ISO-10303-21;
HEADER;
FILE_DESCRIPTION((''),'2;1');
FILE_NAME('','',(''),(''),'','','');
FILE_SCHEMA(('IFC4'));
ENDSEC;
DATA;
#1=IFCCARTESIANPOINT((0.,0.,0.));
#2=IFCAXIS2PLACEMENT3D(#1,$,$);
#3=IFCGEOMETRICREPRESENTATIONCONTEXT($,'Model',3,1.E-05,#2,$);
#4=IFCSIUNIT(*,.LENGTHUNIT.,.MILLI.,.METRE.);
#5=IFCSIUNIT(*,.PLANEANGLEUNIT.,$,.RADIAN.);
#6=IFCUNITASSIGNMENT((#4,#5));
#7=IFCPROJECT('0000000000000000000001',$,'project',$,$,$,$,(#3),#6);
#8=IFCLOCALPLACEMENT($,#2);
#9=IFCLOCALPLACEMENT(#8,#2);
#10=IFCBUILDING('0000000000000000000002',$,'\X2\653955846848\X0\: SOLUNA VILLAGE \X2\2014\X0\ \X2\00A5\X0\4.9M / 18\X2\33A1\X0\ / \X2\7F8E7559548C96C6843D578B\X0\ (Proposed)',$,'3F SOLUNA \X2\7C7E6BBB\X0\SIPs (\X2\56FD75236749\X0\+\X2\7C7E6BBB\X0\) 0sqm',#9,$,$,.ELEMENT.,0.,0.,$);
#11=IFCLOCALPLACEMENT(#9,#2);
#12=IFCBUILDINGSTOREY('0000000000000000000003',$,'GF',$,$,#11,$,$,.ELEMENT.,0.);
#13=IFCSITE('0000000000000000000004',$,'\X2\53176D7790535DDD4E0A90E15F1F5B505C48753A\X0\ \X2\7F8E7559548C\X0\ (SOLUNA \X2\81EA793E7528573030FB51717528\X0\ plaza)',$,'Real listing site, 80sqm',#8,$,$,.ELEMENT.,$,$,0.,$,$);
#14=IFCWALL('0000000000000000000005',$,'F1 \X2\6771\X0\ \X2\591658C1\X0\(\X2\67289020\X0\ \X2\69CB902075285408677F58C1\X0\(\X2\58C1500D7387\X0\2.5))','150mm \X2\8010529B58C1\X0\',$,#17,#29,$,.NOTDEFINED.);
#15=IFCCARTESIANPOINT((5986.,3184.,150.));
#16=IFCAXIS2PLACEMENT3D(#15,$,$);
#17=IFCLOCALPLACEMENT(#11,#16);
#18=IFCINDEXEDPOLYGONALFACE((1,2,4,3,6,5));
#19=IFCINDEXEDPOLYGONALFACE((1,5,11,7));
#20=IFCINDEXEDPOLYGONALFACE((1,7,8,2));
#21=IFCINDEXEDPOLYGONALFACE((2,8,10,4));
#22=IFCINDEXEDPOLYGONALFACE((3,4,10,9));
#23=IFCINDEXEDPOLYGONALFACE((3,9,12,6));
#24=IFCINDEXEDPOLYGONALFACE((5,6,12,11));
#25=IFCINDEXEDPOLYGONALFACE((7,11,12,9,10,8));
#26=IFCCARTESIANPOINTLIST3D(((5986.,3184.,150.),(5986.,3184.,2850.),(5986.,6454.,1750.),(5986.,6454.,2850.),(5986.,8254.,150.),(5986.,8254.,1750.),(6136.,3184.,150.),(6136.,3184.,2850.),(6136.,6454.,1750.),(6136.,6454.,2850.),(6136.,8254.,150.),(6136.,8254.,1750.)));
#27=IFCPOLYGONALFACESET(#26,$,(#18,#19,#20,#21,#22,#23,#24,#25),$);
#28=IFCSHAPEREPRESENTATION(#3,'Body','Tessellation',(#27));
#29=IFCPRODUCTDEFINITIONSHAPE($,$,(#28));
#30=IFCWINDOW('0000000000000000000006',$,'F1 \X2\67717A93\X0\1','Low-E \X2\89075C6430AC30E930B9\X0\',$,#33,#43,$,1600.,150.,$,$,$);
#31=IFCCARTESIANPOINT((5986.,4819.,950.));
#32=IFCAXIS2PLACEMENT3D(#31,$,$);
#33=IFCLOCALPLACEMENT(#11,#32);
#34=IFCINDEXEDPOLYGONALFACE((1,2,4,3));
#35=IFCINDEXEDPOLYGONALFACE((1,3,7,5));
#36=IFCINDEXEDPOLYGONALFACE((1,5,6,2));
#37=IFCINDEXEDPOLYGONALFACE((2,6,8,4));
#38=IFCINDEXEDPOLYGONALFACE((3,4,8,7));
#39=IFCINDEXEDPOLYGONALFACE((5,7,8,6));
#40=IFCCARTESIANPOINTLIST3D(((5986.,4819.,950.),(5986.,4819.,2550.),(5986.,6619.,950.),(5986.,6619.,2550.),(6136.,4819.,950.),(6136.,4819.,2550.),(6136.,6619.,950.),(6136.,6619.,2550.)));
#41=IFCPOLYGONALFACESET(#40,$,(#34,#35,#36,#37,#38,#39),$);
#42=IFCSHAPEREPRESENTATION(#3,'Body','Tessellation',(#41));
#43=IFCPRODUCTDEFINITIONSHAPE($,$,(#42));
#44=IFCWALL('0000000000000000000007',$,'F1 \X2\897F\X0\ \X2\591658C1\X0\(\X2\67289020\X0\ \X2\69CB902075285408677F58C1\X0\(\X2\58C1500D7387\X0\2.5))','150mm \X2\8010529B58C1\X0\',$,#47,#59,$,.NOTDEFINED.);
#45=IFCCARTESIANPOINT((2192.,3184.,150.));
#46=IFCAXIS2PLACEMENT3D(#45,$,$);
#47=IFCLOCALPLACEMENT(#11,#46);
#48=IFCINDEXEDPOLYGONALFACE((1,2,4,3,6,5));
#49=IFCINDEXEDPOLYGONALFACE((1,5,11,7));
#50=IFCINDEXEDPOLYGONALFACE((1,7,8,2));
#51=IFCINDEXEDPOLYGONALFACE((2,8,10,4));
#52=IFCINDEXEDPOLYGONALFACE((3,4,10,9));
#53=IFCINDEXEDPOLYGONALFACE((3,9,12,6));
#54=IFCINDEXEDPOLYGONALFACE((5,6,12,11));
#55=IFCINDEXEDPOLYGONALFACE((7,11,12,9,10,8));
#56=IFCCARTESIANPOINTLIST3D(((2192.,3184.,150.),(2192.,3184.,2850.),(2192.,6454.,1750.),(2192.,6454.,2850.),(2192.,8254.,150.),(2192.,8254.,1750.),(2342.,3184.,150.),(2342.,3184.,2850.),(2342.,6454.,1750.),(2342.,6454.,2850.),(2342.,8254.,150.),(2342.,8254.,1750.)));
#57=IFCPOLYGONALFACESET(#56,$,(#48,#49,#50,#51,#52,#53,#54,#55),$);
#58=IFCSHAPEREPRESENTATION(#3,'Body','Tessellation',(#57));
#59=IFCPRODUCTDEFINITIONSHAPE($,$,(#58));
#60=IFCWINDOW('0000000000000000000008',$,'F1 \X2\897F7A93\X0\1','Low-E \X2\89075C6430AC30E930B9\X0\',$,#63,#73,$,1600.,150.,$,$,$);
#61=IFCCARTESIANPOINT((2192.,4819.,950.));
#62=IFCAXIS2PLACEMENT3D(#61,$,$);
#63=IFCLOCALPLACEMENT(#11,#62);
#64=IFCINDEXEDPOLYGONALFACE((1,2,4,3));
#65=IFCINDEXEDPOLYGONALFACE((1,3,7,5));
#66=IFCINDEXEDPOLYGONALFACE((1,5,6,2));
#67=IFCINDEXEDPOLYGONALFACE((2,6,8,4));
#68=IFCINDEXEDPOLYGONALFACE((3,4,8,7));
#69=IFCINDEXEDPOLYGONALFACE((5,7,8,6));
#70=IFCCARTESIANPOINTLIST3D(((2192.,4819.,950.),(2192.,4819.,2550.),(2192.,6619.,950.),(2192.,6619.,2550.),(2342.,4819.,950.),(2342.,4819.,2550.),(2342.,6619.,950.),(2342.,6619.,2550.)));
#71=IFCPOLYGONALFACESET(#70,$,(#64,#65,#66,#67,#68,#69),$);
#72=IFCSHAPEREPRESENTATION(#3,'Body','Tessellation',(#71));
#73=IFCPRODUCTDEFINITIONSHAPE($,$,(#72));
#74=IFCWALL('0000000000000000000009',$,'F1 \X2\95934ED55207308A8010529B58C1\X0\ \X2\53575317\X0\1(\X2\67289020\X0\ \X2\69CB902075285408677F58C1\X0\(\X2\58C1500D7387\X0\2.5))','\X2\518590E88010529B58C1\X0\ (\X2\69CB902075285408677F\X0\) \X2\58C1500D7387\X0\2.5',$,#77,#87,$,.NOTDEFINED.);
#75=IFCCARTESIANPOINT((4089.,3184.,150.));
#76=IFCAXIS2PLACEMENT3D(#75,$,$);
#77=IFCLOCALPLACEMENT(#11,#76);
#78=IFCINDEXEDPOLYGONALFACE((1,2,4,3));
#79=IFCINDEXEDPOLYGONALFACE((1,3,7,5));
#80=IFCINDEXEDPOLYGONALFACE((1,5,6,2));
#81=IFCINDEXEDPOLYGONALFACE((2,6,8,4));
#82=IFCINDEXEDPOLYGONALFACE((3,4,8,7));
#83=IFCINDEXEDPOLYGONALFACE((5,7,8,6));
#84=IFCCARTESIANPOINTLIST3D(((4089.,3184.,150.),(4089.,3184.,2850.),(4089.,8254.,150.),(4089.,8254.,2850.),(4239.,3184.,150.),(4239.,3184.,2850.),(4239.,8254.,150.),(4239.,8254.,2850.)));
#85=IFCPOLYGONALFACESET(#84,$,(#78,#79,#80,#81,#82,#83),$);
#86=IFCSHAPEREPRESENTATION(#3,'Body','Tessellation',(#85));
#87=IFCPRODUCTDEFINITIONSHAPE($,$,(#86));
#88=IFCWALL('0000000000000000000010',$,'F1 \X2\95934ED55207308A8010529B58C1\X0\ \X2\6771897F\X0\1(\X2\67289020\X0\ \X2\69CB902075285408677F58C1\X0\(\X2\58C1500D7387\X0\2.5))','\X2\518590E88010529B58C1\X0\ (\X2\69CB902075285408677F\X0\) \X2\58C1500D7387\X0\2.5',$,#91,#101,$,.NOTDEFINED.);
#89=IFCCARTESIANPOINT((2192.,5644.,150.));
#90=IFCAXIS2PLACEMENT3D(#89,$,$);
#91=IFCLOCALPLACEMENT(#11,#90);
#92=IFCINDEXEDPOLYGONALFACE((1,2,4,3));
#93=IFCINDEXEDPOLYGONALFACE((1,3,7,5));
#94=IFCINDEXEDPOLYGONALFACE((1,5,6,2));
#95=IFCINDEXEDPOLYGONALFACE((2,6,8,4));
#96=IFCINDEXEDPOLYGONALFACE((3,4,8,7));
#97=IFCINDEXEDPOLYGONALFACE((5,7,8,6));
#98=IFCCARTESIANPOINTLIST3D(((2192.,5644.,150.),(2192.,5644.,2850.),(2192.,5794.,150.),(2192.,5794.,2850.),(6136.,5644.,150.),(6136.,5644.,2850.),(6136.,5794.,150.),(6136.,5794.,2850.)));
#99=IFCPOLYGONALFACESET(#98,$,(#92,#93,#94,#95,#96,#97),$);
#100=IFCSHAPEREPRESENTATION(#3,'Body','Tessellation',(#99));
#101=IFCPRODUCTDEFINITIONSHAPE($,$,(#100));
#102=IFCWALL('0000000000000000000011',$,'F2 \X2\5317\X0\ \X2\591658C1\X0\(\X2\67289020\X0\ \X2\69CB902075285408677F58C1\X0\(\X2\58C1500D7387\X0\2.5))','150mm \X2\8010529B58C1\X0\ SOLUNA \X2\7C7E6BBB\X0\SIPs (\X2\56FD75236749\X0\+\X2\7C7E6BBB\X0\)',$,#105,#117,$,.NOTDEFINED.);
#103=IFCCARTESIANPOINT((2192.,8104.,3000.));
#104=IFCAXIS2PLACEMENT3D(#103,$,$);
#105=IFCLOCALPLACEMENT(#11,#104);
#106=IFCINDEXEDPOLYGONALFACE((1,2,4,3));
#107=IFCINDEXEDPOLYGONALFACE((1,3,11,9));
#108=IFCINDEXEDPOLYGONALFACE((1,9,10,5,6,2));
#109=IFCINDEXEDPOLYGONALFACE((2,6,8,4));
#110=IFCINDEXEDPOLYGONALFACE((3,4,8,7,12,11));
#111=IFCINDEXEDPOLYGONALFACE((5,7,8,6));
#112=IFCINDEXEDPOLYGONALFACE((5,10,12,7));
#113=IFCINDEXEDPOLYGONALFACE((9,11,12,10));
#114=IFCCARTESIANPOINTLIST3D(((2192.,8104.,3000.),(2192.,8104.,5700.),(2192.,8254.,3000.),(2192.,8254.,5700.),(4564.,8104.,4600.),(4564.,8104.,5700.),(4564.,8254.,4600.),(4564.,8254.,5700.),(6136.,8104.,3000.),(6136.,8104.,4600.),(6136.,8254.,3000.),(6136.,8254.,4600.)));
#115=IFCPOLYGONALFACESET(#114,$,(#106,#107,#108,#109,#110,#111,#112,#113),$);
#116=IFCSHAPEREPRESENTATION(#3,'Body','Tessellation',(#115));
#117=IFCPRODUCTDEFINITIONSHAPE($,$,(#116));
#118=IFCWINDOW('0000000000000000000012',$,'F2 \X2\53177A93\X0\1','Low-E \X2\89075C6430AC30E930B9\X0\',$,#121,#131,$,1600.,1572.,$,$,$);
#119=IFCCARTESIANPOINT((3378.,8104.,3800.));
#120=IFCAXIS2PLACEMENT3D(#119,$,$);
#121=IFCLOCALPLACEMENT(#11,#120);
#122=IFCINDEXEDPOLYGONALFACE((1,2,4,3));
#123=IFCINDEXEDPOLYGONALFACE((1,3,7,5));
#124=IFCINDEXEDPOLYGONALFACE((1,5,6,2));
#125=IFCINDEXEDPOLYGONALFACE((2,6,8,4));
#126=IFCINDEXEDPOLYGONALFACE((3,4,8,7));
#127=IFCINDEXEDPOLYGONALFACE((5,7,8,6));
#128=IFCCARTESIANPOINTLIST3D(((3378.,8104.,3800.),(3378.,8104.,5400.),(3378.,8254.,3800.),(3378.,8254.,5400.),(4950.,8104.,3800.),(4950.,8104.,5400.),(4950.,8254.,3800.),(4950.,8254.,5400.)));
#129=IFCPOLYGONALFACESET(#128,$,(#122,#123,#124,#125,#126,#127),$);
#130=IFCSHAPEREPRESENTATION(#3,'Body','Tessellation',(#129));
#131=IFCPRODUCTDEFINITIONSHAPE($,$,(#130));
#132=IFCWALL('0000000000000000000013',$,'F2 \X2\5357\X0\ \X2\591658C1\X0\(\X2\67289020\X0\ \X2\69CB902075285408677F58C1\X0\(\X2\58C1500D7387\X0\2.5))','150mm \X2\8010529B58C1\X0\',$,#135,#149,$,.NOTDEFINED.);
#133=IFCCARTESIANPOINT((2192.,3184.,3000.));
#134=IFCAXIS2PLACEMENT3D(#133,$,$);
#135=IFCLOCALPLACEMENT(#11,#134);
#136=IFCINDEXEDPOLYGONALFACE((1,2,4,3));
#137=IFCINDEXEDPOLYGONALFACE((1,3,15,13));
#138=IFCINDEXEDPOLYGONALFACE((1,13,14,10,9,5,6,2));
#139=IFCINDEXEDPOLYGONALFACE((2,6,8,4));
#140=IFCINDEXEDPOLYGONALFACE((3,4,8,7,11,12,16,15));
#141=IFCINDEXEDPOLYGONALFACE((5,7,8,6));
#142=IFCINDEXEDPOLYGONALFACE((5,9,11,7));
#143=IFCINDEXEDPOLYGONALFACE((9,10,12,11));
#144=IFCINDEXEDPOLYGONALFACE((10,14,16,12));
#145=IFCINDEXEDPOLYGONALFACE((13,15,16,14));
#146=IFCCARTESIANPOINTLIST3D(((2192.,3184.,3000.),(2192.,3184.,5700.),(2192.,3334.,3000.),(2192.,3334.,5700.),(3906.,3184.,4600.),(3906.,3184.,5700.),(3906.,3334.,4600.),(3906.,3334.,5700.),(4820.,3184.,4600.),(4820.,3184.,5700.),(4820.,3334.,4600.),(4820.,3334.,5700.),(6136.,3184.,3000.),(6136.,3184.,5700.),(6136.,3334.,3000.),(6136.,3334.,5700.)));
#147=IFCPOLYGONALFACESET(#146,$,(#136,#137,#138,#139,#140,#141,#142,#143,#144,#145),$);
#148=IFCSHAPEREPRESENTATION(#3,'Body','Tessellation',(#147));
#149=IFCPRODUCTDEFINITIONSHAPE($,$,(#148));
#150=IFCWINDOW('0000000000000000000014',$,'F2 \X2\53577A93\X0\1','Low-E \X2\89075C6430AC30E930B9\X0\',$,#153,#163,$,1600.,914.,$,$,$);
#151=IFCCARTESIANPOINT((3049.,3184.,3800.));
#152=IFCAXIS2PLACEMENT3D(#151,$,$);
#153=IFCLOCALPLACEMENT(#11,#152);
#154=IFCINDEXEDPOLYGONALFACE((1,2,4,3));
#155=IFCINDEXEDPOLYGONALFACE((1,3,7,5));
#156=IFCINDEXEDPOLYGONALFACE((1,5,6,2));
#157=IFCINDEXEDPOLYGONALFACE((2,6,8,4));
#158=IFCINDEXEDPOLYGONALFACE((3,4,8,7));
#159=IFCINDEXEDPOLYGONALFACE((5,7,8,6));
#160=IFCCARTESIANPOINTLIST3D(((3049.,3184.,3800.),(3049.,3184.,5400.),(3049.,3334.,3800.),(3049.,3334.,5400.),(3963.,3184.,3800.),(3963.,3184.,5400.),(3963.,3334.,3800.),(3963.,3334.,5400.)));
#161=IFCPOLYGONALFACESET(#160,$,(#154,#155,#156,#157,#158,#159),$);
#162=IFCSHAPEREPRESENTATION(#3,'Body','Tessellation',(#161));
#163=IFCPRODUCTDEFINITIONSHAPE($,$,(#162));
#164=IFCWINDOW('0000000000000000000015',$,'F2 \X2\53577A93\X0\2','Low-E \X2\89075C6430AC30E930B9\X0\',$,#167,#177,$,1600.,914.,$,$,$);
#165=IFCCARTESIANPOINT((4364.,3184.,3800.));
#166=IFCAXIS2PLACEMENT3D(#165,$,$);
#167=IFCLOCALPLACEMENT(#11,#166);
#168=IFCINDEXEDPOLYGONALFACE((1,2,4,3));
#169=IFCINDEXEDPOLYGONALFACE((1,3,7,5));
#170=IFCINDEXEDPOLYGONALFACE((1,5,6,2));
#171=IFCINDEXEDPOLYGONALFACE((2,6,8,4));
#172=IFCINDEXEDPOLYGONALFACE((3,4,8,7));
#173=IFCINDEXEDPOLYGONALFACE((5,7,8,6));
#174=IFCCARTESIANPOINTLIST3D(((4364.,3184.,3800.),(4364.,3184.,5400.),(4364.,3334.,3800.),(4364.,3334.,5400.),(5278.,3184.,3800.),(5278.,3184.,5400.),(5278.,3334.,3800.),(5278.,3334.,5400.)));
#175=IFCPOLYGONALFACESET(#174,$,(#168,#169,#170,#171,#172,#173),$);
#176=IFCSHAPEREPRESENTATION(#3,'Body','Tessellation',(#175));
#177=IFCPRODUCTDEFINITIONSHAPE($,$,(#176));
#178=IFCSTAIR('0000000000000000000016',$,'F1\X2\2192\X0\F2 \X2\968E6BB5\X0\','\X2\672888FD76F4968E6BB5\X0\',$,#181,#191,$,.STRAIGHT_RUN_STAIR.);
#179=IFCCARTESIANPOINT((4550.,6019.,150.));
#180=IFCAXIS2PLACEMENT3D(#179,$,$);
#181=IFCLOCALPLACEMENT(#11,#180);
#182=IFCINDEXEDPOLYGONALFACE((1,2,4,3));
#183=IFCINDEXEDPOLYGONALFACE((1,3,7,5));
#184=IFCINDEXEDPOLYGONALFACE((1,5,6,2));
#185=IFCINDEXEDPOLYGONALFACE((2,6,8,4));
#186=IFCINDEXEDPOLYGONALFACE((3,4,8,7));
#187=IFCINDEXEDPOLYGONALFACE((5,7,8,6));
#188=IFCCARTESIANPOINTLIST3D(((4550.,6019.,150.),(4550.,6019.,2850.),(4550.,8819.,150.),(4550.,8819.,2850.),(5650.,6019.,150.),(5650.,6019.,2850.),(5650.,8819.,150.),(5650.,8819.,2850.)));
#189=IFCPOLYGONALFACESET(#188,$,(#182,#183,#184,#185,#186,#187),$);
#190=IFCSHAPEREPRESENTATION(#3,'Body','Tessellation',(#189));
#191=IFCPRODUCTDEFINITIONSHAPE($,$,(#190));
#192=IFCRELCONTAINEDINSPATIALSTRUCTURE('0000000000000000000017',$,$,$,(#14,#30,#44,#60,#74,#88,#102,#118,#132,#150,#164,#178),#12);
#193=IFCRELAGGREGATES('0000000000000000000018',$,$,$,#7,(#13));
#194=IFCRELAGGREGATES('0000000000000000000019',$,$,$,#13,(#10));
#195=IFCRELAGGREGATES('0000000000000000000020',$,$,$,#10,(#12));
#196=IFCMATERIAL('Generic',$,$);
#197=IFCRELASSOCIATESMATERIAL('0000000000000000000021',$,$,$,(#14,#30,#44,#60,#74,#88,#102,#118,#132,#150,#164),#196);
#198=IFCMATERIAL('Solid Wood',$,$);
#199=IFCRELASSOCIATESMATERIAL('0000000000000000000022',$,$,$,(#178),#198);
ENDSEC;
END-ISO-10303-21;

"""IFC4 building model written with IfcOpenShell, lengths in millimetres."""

from ifc_helpers import new_model, si_unit, frame, frame_2d, origin, place, context, project, spatial, rectangle, extrude, material, element, fill, save


model = new_model("IFC4")

# Units and contexts
model_context = context("Model", 3, precision=1e-05, world=origin())
ifc_project = project(units=[si_unit("LENGTHUNIT", "METRE", prefix="MILLI"), si_unit("PLANEANGLEUNIT", "RADIAN")], contexts=[model_context])

# Site, building, storey
site_placement = place(None, origin())
site = spatial("IfcSite", under=ifc_project, at=site_placement, Name="北海道川上郡弟子屈町 美留和 (SOLUNA 自社用地・共用 plaza)", ObjectType="Real listing site, 80sqm", CompositionType="ELEMENT", RefElevation=0.0)
building_placement = place(site_placement, origin())
building = spatial("IfcBuilding", under=site, at=building_placement, Name="改善案: SOLUNA VILLAGE — ¥4.9M / 18㎡ / 美留和集落型 (Proposed)", ObjectType="3F SOLUNA 籾殻SIPs (国産杉+籾殻) 0sqm", CompositionType="ELEMENT", ElevationOfRefHeight=0.0, ElevationOfTerrain=0.0)
storey_placement = place(building_placement, origin())
storey = spatial("IfcBuildingStorey", under=building, at=storey_placement, Name="GF", CompositionType="ELEMENT", Elevation=0.0)

# Shared definitions
ifc_material_1 = material(Name="Generic")

# Shared definitions
ifc_material_2 = material(Name="Solid Wood")

# Walls, openings, windows
wall_1_placement = place(storey_placement, frame((5986.0, 3184.0, 150.0)))
wall_1 = element("IfcWall", 1, at=wall_1_placement, inside=storey, material=ifc_material_1, Name="F1 東 外壁(木造 構造用合板壁(壁倍率2.5))", Description="150mm 耐力壁", PredefinedType="NOTDEFINED", context=model_context, shape_type="SweptSolid", body=[
    extrude(rectangle(XDim=150.0, YDim=5070.0, at=frame_2d((75.0, 2535.0))), frame((5986.0, 3184.0, 150.0)), (0.0, 0.0, 1.0), 2700.0),
])
opening_1_placement = place(storey_placement, frame((5986.0, 4819.0, 950.0)))
opening_1 = element("IfcOpeningElement", 2, at=opening_1_placement, cuts=wall_1, PredefinedType="NOTDEFINED", context=model_context, shape_type="SweptSolid", body=[
    extrude(rectangle(XDim=150.0, YDim=1800.0, at=frame_2d((75.0, 900.0))), frame((5986.0, 4819.0, 950.0)), (0.0, 0.0, 1.0), 1600.0),
])
window_1_placement = place(storey_placement, frame((5986.0, 4819.0, 950.0)))
window_1 = element("IfcWindow", 3, at=window_1_placement, inside=storey, material=ifc_material_1, Name="F1 東窓1", Description="Low-E 複層ガラス", OverallHeight=1600.0, OverallWidth=150.0, context=model_context, shape_type="SweptSolid", body=[
    extrude(rectangle(XDim=150.0, YDim=1800.0, at=frame_2d((75.0, 900.0))), frame((5986.0, 4819.0, 950.0)), (0.0, 0.0, 1.0), 1600.0),
])
fill(opening_1, window_1)
wall_2_placement = place(storey_placement, frame((2192.0, 3184.0, 150.0)))
wall_2 = element("IfcWall", 4, at=wall_2_placement, inside=storey, material=ifc_material_1, Name="F1 西 外壁(木造 構造用合板壁(壁倍率2.5))", Description="150mm 耐力壁", PredefinedType="NOTDEFINED", context=model_context, shape_type="SweptSolid", body=[
    extrude(rectangle(XDim=150.0, YDim=5070.0, at=frame_2d((75.0, 2535.0))), frame((2192.0, 3184.0, 150.0)), (0.0, 0.0, 1.0), 2700.0),
])
opening_2_placement = place(storey_placement, frame((2192.0, 4819.0, 950.0)))
opening_2 = element("IfcOpeningElement", 5, at=opening_2_placement, cuts=wall_2, PredefinedType="NOTDEFINED", context=model_context, shape_type="SweptSolid", body=[
    extrude(rectangle(XDim=150.0, YDim=1800.0, at=frame_2d((75.0, 900.0))), frame((2192.0, 4819.0, 950.0)), (0.0, 0.0, 1.0), 1600.0),
])
window_2_placement = place(storey_placement, frame((2192.0, 4819.0, 950.0)))
window_2 = element("IfcWindow", 6, at=window_2_placement, inside=storey, material=ifc_material_1, Name="F1 西窓1", Description="Low-E 複層ガラス", OverallHeight=1600.0, OverallWidth=150.0, context=model_context, shape_type="SweptSolid", body=[
    extrude(rectangle(XDim=150.0, YDim=1800.0, at=frame_2d((75.0, 900.0))), frame((2192.0, 4819.0, 950.0)), (0.0, 0.0, 1.0), 1600.0),
])
fill(opening_2, window_2)

# Walls
wall_3_placement = place(storey_placement, frame((4089.0, 3184.0, 150.0)))
element("IfcWall", 7, at=wall_3_placement, inside=storey, material=ifc_material_1, Name="F1 間仕切り耐力壁 南北1(木造 構造用合板壁(壁倍率2.5))", Description="内部耐力壁 (構造用合板) 壁倍率2.5", PredefinedType="NOTDEFINED", context=model_context, shape_type="SweptSolid", body=[
    extrude(rectangle(XDim=150.0, YDim=5070.0, at=frame_2d((75.0, 2535.0))), frame((4089.0, 3184.0, 150.0)), (0.0, 0.0, 1.0), 2700.0),
])
wall_4_placement = place(storey_placement, frame((2192.0, 5644.0, 150.0)))
element("IfcWall", 8, at=wall_4_placement, inside=storey, material=ifc_material_1, Name="F1 間仕切り耐力壁 東西1(木造 構造用合板壁(壁倍率2.5))", Description="内部耐力壁 (構造用合板) 壁倍率2.5", PredefinedType="NOTDEFINED", context=model_context, shape_type="SweptSolid", body=[
    extrude(rectangle(XDim=3944.0, YDim=150.0, at=frame_2d((1972.0, 75.0))), frame((2192.0, 5644.0, 150.0)), (0.0, 0.0, 1.0), 2700.0),
])

# Wall, opening, window
wall_5_placement = place(storey_placement, frame((2192.0, 8104.0, 3000.0)))
wall_5 = element("IfcWall", 9, at=wall_5_placement, inside=storey, material=ifc_material_1, Name="F2 北 外壁(木造 構造用合板壁(壁倍率2.5))", Description="150mm 耐力壁 SOLUNA 籾殻SIPs (国産杉+籾殻)", PredefinedType="NOTDEFINED", context=model_context, shape_type="SweptSolid", body=[
    extrude(rectangle(XDim=3944.0, YDim=150.0, at=frame_2d((1972.0, 75.0))), frame((2192.0, 8104.0, 3000.0)), (0.0, 0.0, 1.0), 2700.0),
])
opening_3_placement = place(storey_placement, frame((3378.0, 8104.0, 3800.0)))
opening_3 = element("IfcOpeningElement", 10, at=opening_3_placement, cuts=wall_5, PredefinedType="NOTDEFINED", context=model_context, shape_type="SweptSolid", body=[
    extrude(rectangle(XDim=1572.0, YDim=150.0, at=frame_2d((786.0, 75.0))), frame((3378.0, 8104.0, 3800.0)), (0.0, 0.0, 1.0), 1600.0),
])
window_3_placement = place(storey_placement, frame((3378.0, 8104.0, 3800.0)))
window_3 = element("IfcWindow", 11, at=window_3_placement, inside=storey, material=ifc_material_1, Name="F2 北窓1", Description="Low-E 複層ガラス", OverallHeight=1600.0, OverallWidth=1572.0, context=model_context, shape_type="SweptSolid", body=[
    extrude(rectangle(XDim=1572.0, YDim=150.0, at=frame_2d((786.0, 75.0))), frame((3378.0, 8104.0, 3800.0)), (0.0, 0.0, 1.0), 1600.0),
])
fill(opening_3, window_3)

# Wall, openings, windows
wall_6_placement = place(storey_placement, frame((2192.0, 3184.0, 3000.0)))
wall_6 = element("IfcWall", 12, at=wall_6_placement, inside=storey, material=ifc_material_1, Name="F2 南 外壁(木造 構造用合板壁(壁倍率2.5))", Description="150mm 耐力壁", PredefinedType="NOTDEFINED", context=model_context, shape_type="SweptSolid", body=[
    extrude(rectangle(XDim=3944.0, YDim=150.0, at=frame_2d((1972.0, 75.0))), frame((2192.0, 3184.0, 3000.0)), (0.0, 0.0, 1.0), 2700.0),
])
opening_4_placement = place(storey_placement, frame((3049.0, 3184.0, 3800.0)))
opening_4 = element("IfcOpeningElement", 13, at=opening_4_placement, cuts=wall_6, PredefinedType="NOTDEFINED", context=model_context, shape_type="SweptSolid", body=[
    extrude(rectangle(XDim=914.0, YDim=150.0, at=frame_2d((457.0, 75.0))), frame((3049.0, 3184.0, 3800.0)), (0.0, 0.0, 1.0), 1600.0),
])
opening_5_placement = place(storey_placement, frame((4364.0, 3184.0, 3800.0)))
opening_5 = element("IfcOpeningElement", 14, at=opening_5_placement, cuts=wall_6, PredefinedType="NOTDEFINED", context=model_context, shape_type="SweptSolid", body=[
    extrude(rectangle(XDim=914.0, YDim=150.0, at=frame_2d((457.0, 75.0))), frame((4364.0, 3184.0, 3800.0)), (0.0, 0.0, 1.0), 1600.0),
])
window_4_placement = place(storey_placement, frame((3049.0, 3184.0, 3800.0)))
window_4 = element("IfcWindow", 15, at=window_4_placement, inside=storey, material=ifc_material_1, Name="F2 南窓1", Description="Low-E 複層ガラス", OverallHeight=1600.0, OverallWidth=914.0, context=model_context, shape_type="SweptSolid", body=[
    extrude(rectangle(XDim=914.0, YDim=150.0, at=frame_2d((457.0, 75.0))), frame((3049.0, 3184.0, 3800.0)), (0.0, 0.0, 1.0), 1600.0),
])
fill(opening_4, window_4)
window_5_placement = place(storey_placement, frame((4364.0, 3184.0, 3800.0)))
window_5 = element("IfcWindow", 16, at=window_5_placement, inside=storey, material=ifc_material_1, Name="F2 南窓2", Description="Low-E 複層ガラス", OverallHeight=1600.0, OverallWidth=914.0, context=model_context, shape_type="SweptSolid", body=[
    extrude(rectangle(XDim=914.0, YDim=150.0, at=frame_2d((457.0, 75.0))), frame((4364.0, 3184.0, 3800.0)), (0.0, 0.0, 1.0), 1600.0),
])
fill(opening_5, window_5)

# Stair
stair_placement = place(storey_placement, frame((4550.0, 6019.0, 150.0)))
element("IfcStair", 17, at=stair_placement, inside=storey, material=ifc_material_2, Name="F1→F2 階段", Description="木製直階段", PredefinedType="STRAIGHT_RUN_STAIR", context=model_context, shape_type="SweptSolid", body=[
    extrude(rectangle(XDim=1100.0, YDim=2800.0, at=frame_2d((550.0, 1400.0))), frame((4550.0, 6019.0, 150.0)), (0.0, 0.0, 1.0), 2700.0),
])

save(model, "model.ifc")
